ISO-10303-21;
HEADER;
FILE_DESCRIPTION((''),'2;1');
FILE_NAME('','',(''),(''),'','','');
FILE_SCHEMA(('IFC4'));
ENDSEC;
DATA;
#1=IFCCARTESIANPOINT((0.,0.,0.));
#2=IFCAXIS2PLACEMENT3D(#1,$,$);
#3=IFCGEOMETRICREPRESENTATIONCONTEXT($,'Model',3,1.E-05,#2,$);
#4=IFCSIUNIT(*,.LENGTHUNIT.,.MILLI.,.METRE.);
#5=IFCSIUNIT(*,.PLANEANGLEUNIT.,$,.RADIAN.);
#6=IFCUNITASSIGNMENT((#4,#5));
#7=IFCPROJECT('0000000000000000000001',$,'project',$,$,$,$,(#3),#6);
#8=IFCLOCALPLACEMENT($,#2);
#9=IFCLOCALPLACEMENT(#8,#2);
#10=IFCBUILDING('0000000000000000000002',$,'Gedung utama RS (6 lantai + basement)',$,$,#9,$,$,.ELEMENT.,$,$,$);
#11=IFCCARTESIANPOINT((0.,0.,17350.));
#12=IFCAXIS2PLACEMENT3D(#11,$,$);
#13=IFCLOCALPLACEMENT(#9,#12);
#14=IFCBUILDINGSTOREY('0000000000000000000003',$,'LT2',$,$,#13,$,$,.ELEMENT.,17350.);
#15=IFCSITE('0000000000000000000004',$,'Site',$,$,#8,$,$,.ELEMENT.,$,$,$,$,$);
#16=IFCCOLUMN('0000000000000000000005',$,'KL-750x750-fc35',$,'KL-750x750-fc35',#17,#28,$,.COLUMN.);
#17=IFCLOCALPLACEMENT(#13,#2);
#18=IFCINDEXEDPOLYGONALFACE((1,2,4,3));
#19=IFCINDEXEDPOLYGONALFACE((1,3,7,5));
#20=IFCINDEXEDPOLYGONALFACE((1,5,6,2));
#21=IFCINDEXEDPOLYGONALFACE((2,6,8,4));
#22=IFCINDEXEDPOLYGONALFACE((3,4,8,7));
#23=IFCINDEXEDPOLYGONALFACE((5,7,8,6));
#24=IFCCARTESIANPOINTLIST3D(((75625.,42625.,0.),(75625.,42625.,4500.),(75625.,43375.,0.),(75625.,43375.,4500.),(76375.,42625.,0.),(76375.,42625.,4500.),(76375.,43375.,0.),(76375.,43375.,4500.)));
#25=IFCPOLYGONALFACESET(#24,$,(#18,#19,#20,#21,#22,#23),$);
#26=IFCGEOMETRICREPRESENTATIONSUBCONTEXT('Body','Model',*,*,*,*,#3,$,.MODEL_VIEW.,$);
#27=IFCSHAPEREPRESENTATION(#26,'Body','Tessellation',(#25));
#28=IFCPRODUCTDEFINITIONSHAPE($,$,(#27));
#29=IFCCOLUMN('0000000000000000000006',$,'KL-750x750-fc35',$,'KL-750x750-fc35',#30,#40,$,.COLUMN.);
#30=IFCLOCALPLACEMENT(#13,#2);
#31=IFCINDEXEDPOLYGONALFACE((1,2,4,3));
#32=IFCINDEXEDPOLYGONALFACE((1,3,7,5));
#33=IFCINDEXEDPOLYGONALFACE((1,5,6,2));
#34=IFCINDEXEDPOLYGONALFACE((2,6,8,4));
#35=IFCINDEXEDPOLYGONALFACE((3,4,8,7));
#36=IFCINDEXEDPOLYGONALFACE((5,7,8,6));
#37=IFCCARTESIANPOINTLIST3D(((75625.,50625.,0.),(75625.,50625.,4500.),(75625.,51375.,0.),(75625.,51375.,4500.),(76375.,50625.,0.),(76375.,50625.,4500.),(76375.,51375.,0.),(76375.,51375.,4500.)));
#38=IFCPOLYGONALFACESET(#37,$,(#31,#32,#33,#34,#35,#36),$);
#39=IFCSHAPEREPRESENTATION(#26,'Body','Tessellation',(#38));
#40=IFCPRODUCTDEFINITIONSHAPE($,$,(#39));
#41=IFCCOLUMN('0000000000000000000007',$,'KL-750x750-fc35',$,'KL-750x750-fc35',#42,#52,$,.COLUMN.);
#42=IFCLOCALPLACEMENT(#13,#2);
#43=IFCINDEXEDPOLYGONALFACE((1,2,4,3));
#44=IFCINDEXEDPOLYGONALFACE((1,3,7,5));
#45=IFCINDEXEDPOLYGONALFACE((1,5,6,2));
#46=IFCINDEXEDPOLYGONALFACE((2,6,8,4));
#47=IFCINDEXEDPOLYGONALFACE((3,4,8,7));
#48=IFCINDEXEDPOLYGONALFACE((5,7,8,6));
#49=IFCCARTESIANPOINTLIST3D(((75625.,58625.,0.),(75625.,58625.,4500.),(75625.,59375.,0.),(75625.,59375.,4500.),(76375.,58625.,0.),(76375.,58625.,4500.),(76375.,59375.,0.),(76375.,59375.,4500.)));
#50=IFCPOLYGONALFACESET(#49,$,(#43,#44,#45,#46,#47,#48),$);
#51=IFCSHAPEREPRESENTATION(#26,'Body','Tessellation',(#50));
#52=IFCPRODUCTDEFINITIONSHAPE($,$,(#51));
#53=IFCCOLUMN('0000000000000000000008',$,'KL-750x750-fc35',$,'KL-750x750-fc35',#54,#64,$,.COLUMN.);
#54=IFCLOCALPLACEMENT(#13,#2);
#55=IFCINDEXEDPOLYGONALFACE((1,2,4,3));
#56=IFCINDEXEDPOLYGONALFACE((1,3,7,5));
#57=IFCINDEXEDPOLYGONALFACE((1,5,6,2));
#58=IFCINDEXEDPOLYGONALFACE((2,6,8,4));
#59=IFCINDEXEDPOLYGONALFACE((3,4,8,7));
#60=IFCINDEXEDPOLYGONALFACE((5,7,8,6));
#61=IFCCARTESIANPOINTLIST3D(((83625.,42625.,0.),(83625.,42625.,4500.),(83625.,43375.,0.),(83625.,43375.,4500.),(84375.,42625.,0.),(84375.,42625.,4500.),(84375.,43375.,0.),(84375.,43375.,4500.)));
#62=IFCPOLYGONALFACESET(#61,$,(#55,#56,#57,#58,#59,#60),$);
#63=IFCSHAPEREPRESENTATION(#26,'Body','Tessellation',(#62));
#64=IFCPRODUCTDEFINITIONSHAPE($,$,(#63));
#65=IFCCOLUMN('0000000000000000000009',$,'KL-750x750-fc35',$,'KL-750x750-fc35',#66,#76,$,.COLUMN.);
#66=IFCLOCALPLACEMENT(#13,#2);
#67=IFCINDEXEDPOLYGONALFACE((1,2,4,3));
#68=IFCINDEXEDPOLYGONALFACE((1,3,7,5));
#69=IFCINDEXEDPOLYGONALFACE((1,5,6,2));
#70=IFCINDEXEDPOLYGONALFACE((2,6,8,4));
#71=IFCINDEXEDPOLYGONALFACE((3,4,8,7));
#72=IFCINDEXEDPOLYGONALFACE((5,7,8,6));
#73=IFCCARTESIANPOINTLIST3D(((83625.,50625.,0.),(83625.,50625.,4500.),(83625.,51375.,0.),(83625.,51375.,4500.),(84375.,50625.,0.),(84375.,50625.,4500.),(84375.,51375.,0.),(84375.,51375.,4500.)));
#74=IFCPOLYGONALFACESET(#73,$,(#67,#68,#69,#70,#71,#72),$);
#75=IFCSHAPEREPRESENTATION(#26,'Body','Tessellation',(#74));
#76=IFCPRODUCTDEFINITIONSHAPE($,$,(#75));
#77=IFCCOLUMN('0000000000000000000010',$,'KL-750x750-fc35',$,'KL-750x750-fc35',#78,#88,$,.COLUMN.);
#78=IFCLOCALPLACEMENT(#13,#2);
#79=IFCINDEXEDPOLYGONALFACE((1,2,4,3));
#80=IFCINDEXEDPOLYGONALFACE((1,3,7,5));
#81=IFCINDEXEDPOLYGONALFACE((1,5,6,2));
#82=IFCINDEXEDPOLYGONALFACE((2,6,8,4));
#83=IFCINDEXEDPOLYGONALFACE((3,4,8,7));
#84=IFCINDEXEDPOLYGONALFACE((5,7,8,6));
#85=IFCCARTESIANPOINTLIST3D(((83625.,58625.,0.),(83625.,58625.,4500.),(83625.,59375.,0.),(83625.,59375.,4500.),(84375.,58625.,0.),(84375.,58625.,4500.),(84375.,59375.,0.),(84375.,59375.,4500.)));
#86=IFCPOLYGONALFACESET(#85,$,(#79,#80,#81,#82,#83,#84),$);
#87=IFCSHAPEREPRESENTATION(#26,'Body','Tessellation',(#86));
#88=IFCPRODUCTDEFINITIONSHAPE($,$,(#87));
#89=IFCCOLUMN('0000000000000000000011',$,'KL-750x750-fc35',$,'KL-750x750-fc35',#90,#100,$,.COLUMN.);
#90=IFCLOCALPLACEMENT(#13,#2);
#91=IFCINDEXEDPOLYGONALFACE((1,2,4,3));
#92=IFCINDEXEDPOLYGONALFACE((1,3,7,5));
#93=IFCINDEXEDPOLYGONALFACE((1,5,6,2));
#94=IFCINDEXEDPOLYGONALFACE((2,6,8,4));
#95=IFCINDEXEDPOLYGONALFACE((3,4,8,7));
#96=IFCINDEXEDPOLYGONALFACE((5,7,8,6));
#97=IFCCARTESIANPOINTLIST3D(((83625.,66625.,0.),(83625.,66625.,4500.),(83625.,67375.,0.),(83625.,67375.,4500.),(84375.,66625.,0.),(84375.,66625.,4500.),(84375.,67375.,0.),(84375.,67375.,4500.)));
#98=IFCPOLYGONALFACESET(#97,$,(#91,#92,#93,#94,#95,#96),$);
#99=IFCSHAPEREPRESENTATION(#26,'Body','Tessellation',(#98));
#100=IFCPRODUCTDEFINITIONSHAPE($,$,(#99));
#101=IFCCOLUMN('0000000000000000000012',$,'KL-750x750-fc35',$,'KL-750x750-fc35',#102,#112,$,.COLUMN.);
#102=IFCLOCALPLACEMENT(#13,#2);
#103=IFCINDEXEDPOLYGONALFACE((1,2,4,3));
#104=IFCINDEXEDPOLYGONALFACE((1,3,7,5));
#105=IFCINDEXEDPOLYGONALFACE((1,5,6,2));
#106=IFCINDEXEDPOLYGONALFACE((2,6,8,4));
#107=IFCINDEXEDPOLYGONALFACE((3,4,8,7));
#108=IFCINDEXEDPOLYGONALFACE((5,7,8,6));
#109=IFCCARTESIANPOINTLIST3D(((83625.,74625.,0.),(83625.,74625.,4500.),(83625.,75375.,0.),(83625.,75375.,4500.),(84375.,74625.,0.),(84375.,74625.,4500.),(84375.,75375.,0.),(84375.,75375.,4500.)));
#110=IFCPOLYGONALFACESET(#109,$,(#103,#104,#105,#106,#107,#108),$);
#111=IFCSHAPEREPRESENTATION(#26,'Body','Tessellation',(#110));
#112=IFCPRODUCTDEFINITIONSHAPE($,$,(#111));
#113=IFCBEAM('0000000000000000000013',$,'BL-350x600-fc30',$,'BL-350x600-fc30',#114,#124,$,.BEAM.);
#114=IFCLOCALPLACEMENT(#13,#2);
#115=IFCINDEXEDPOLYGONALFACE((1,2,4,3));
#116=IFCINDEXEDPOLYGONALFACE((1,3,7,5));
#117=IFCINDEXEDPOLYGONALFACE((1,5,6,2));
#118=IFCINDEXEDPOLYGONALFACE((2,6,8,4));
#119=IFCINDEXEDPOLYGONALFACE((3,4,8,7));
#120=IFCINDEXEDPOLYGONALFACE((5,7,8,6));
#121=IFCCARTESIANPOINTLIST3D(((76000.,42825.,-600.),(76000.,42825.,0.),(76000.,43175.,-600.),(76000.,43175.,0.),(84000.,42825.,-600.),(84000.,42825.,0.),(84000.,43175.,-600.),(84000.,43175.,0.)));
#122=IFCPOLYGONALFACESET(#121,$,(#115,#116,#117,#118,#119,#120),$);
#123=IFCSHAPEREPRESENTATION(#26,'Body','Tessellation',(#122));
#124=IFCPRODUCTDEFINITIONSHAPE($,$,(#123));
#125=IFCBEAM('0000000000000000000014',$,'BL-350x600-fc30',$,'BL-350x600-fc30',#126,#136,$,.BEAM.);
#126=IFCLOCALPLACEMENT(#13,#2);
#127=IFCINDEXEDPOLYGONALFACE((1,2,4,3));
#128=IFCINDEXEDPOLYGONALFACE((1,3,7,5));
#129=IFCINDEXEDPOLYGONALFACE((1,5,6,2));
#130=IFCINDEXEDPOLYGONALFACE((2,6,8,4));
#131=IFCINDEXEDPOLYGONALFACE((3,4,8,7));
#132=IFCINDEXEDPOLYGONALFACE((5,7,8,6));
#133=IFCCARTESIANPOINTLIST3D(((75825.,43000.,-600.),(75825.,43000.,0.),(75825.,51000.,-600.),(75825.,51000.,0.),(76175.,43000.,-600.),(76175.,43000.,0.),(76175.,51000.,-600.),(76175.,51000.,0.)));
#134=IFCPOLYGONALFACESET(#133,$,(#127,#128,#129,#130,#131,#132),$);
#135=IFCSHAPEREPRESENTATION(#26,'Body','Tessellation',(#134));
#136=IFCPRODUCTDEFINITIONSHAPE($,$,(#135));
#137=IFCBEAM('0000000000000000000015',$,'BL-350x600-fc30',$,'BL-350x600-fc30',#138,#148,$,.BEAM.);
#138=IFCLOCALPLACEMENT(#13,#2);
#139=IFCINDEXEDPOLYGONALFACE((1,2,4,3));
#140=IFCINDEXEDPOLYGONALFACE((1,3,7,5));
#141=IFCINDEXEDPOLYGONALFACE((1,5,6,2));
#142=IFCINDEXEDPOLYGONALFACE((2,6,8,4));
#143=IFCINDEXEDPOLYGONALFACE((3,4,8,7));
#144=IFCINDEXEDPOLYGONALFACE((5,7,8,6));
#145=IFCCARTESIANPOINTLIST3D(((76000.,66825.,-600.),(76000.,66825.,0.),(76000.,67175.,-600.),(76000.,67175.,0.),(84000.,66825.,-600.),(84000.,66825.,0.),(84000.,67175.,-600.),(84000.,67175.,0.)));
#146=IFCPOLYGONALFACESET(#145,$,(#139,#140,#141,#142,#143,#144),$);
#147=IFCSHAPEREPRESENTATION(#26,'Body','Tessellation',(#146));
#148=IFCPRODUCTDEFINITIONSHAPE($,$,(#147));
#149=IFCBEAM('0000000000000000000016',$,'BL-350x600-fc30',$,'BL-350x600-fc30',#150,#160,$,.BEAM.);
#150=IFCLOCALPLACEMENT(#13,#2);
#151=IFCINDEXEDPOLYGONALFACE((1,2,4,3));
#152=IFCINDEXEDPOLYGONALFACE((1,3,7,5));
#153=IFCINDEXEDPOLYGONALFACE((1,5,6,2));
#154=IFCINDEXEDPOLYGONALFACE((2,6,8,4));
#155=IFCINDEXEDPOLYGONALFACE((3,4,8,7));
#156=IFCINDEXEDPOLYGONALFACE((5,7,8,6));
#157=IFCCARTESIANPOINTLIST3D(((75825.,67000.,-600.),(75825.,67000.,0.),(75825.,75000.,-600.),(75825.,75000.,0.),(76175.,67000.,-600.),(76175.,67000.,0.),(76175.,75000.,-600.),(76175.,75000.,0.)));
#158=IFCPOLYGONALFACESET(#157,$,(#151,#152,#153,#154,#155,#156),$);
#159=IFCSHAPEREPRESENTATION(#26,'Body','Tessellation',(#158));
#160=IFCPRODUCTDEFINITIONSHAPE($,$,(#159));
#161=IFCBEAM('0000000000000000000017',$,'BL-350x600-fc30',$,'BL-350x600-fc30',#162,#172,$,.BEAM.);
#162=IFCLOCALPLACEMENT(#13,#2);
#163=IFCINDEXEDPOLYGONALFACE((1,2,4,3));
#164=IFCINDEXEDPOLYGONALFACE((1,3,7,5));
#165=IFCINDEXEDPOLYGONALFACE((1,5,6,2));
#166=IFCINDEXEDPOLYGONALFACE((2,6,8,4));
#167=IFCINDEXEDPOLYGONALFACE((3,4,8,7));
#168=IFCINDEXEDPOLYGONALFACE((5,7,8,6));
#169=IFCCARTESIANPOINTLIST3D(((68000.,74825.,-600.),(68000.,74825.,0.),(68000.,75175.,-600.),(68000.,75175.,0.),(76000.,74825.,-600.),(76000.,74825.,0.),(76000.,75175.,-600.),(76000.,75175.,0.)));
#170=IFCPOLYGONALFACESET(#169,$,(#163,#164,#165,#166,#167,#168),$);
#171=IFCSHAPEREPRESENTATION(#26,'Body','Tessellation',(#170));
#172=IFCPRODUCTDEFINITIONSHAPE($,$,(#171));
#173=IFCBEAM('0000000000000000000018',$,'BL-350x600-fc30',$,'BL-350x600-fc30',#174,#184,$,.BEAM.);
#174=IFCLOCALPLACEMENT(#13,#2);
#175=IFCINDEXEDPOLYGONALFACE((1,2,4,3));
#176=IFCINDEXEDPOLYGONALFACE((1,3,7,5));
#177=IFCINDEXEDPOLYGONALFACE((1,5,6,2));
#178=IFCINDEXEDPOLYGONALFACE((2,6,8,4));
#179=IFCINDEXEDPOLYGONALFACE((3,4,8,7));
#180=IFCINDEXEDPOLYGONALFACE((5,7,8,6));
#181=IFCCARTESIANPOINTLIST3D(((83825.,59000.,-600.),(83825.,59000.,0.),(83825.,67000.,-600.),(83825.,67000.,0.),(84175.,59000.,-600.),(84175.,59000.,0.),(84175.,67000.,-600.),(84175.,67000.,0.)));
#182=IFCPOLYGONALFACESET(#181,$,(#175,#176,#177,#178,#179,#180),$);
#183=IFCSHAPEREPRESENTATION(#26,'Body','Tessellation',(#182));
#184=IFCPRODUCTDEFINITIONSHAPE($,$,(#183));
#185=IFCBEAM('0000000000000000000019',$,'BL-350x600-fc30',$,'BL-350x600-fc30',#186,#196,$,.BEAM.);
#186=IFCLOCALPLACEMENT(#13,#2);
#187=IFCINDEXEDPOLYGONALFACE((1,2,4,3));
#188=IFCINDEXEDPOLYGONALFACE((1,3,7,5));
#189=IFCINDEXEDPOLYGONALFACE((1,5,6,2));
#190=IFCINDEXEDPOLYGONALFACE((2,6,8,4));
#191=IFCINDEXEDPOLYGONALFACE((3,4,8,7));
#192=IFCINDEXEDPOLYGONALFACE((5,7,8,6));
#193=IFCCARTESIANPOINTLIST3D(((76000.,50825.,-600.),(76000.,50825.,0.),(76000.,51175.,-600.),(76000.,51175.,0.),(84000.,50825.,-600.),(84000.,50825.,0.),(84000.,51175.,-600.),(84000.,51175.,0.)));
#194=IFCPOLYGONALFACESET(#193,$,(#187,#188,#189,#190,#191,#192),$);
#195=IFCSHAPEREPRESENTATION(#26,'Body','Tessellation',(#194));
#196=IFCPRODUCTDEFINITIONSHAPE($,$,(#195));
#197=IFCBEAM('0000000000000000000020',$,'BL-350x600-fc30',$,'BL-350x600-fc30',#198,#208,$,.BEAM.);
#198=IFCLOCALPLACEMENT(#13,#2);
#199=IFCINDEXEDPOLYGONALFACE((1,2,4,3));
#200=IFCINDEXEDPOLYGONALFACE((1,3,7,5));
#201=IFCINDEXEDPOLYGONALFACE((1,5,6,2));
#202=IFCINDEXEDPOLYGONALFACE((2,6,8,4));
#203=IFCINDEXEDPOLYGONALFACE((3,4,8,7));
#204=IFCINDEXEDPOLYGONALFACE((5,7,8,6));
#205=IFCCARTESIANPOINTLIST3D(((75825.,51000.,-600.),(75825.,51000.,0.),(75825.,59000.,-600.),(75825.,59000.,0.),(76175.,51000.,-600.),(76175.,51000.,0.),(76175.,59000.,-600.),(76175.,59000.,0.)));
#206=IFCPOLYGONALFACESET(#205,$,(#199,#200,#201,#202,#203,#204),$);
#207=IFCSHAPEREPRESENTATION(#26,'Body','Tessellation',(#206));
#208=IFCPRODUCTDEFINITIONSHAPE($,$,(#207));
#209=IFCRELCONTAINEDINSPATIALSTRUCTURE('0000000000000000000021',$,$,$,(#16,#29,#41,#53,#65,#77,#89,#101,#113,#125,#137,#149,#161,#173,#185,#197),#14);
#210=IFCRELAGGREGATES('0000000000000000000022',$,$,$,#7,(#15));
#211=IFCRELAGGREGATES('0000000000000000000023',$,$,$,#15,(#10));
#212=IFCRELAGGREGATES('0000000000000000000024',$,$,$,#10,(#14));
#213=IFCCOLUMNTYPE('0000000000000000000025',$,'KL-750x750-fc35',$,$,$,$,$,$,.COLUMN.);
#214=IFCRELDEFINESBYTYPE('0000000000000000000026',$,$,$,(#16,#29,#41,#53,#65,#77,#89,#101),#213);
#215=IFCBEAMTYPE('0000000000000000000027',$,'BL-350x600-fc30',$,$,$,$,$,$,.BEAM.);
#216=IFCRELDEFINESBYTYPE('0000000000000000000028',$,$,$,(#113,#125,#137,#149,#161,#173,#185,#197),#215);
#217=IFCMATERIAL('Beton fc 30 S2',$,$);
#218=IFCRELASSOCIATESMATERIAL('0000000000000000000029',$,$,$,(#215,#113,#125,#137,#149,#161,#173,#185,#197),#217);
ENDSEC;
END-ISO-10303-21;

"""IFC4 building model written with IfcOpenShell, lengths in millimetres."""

from ifc_helpers import new_model, si_unit, frame, origin, origin_2d, place, context, subcontext, project, spatial, rectangle, extrude, material, material_profile, profile_set, profile_usage, type_object, element, save


model = new_model("IFC4")

# Units and contexts
model_context = context("Model", 3, precision=1e-05, world=origin())
body_context = subcontext(model_context, "Body", "Model", "MODEL_VIEW")
ifc_project = project(units=[si_unit("LENGTHUNIT", "METRE", prefix="MILLI"), si_unit("PLANEANGLEUNIT", "RADIAN")], contexts=[model_context])

# Site, building, storey
site_placement = place(None, origin())
site = spatial("IfcSite", under=ifc_project, at=site_placement, Name="Site", CompositionType="ELEMENT")
building_placement = place(site_placement, origin())
building = spatial("IfcBuilding", under=site, at=building_placement, Name="Gedung utama RS (6 lantai + basement)", CompositionType="ELEMENT")
storey_placement = place(building_placement, frame((0.0, 0.0, 17350.0)))
storey = spatial("IfcBuildingStorey", under=building, at=storey_placement, Name="LT2", CompositionType="ELEMENT", Elevation=17350.0)

# Columns
ifc_material_profile_1 = material_profile(None, rectangle(XDim=750.0, YDim=750.0, at=origin_2d()), Name="KL-750x750-fc35")
ifc_profile_set_1 = profile_set([ifc_material_profile_1], Name="KL-750x750-fc35")
ifc_profile_usage_1 = profile_usage(ifc_profile_set_1, cardinal=5)
column_type = type_object("IfcColumnType", Name="KL-750x750-fc35", PredefinedType="COLUMN", material=ifc_profile_set_1)
for number, where, z_axis, x_axis, name in (
    (1, (76000.0, 43000.0, 0.0), (0.0, 0.0, 1.0), (1.0, 0.0, 0.0), "KL-750x750-fc35"),
    (2, (76000.0, 51000.0, 0.0), (0.0, 0.0, 1.0), (1.0, 0.0, 0.0), "KL-750x750-fc35"),
    (3, (76000.0, 59000.0, 0.0), (0.0, 0.0, 1.0), (1.0, 0.0, 0.0), "KL-750x750-fc35"),
    (4, (84000.0, 43000.0, 0.0), (0.0, 0.0, 1.0), (1.0, 0.0, 0.0), "KL-750x750-fc35"),
    (5, (84000.0, 51000.0, 0.0), (0.0, 0.0, 1.0), (1.0, 0.0, 0.0), "KL-750x750-fc35"),
    (6, (84000.0, 59000.0, 0.0), (0.0, 0.0, 1.0), (1.0, 0.0, 0.0), "KL-750x750-fc35"),
    (7, (84000.0, 67000.0, 0.0), (0.0, 0.0, 1.0), (1.0, 0.0, 0.0), "KL-750x750-fc35"),
    (8, (84000.0, 75000.0, 0.0), (0.0, 0.0, 1.0), (1.0, 0.0, 0.0), "KL-750x750-fc35"),
):
    element("IfcColumn", number, at=place(storey_placement, frame(where, z_axis=z_axis, x_axis=x_axis)), inside=storey, type_object=column_type, material=ifc_profile_usage_1, Name=name, ObjectType="KL-750x750-fc35", PredefinedType="COLUMN", context=body_context, shape_type="SweptSolid", body=[
        extrude(rectangle(XDim=750.0, YDim=750.0, at=origin_2d()), origin(), (0.0, 0.0, 1.0), 4500.0),
    ])

# Beams
ifc_material_1 = material(Name="Beton fc 30 S2")
ifc_material_profile_2 = material_profile(ifc_material_1, rectangle(XDim=350.0, YDim=600.0, at=origin_2d()), Name="BL-350x600-fc30")
ifc_profile_set_2 = profile_set([ifc_material_profile_2], Name="BL-350x600-fc30")
ifc_profile_usage_2 = profile_usage(ifc_profile_set_2, cardinal=8)
beam_type = type_object("IfcBeamType", Name="BL-350x600-fc30", PredefinedType="BEAM", material=ifc_profile_set_2)
beam_1_placement = place(storey_placement, frame((76000.0, 43000.0, -300.0)))
element("IfcBeam", 9, at=beam_1_placement, inside=storey, type_object=beam_type, material=ifc_profile_usage_2, Name="BL-350x600-fc30", ObjectType="BL-350x600-fc30", PredefinedType="BEAM", context=body_context, shape_type="SweptSolid", body=[
    extrude(rectangle(XDim=350.0, YDim=600.0, at=origin_2d()), frame((0.0, 0.0, 0.0), z_axis=(1.0, 0.0, 0.0), x_axis=(0.0, 1.0, 0.0)), (0.0, 0.0, 1.0), 8000.0),
])
beam_2_placement = place(storey_placement, frame((76000.0, 43000.0, -300.0)))
element("IfcBeam", 10, at=beam_2_placement, inside=storey, type_object=beam_type, material=ifc_profile_usage_2, Name="BL-350x600-fc30", ObjectType="BL-350x600-fc30", PredefinedType="BEAM", context=body_context, shape_type="SweptSolid", body=[
    extrude(rectangle(XDim=350.0, YDim=600.0, at=origin_2d()), frame((0.0, 0.0, 0.0), z_axis=(0.0, 1.0, 0.0), x_axis=(-1.0, 0.0, 0.0)), (0.0, 0.0, 1.0), 8000.0),
])
beam_3_placement = place(storey_placement, frame((76000.0, 67000.0, -300.0)))
element("IfcBeam", 11, at=beam_3_placement, inside=storey, type_object=beam_type, material=ifc_profile_usage_2, Name="BL-350x600-fc30", ObjectType="BL-350x600-fc30", PredefinedType="BEAM", context=body_context, shape_type="SweptSolid", body=[
    extrude(rectangle(XDim=350.0, YDim=600.0, at=origin_2d()), frame((0.0, 0.0, 0.0), z_axis=(1.0, 0.0, 0.0), x_axis=(0.0, 1.0, 0.0)), (0.0, 0.0, 1.0), 8000.0),
])
beam_4_placement = place(storey_placement, frame((76000.0, 67000.0, -300.0)))
element("IfcBeam", 12, at=beam_4_placement, inside=storey, type_object=beam_type, material=ifc_profile_usage_2, Name="BL-350x600-fc30", ObjectType="BL-350x600-fc30", PredefinedType="BEAM", context=body_context, shape_type="SweptSolid", body=[
    extrude(rectangle(XDim=350.0, YDim=600.0, at=origin_2d()), frame((0.0, 0.0, 0.0), z_axis=(0.0, 1.0, 0.0), x_axis=(-1.0, 0.0, 0.0)), (0.0, 0.0, 1.0), 8000.0),
])
beam_5_placement = place(storey_placement, frame((68000.0, 75000.0, -300.0)))
element("IfcBeam", 13, at=beam_5_placement, inside=storey, type_object=beam_type, material=ifc_profile_usage_2, Name="BL-350x600-fc30", ObjectType="BL-350x600-fc30", PredefinedType="BEAM", context=body_context, shape_type="SweptSolid", body=[
    extrude(rectangle(XDim=350.0, YDim=600.0, at=origin_2d()), frame((0.0, 0.0, 0.0), z_axis=(1.0, 0.0, 0.0), x_axis=(0.0, 1.0, 0.0)), (0.0, 0.0, 1.0), 8000.0),
])
beam_6_placement = place(storey_placement, frame((84000.0, 59000.0, -300.0)))
element("IfcBeam", 14, at=beam_6_placement, inside=storey, type_object=beam_type, material=ifc_profile_usage_2, Name="BL-350x600-fc30", ObjectType="BL-350x600-fc30", PredefinedType="BEAM", context=body_context, shape_type="SweptSolid", body=[
    extrude(rectangle(XDim=350.0, YDim=600.0, at=origin_2d()), frame((0.0, 0.0, 0.0), z_axis=(0.0, 1.0, 0.0), x_axis=(-1.0, 0.0, 0.0)), (0.0, 0.0, 1.0), 8000.0),
])
beam_7_placement = place(storey_placement, frame((76000.0, 51000.0, -300.0)))
element("IfcBeam", 15, at=beam_7_placement, inside=storey, type_object=beam_type, material=ifc_profile_usage_2, Name="BL-350x600-fc30", ObjectType="BL-350x600-fc30", PredefinedType="BEAM", context=body_context, shape_type="SweptSolid", body=[
    extrude(rectangle(XDim=350.0, YDim=600.0, at=origin_2d()), frame((0.0, 0.0, 0.0), z_axis=(1.0, 0.0, 0.0), x_axis=(0.0, 1.0, 0.0)), (0.0, 0.0, 1.0), 8000.0),
])
for number, where, name in (
    (16, (76000.0, 51000.0, -300.0), "BL-350x600-fc30"),
):
    element("IfcBeam", number, at=place(storey_placement, frame(where)), inside=storey, type_object=beam_type, material=ifc_profile_usage_2, Name=name, ObjectType="BL-350x600-fc30", PredefinedType="BEAM", context=body_context, shape_type="SweptSolid", body=[
        extrude(rectangle(XDim=350.0, YDim=600.0, at=origin_2d()), frame((0.0, 0.0, 0.0), z_axis=(0.0, 1.0, 0.0), x_axis=(-1.0, 0.0, 0.0)), (0.0, 0.0, 1.0), 8000.0),
    ])

save(model, "model.ifc")
